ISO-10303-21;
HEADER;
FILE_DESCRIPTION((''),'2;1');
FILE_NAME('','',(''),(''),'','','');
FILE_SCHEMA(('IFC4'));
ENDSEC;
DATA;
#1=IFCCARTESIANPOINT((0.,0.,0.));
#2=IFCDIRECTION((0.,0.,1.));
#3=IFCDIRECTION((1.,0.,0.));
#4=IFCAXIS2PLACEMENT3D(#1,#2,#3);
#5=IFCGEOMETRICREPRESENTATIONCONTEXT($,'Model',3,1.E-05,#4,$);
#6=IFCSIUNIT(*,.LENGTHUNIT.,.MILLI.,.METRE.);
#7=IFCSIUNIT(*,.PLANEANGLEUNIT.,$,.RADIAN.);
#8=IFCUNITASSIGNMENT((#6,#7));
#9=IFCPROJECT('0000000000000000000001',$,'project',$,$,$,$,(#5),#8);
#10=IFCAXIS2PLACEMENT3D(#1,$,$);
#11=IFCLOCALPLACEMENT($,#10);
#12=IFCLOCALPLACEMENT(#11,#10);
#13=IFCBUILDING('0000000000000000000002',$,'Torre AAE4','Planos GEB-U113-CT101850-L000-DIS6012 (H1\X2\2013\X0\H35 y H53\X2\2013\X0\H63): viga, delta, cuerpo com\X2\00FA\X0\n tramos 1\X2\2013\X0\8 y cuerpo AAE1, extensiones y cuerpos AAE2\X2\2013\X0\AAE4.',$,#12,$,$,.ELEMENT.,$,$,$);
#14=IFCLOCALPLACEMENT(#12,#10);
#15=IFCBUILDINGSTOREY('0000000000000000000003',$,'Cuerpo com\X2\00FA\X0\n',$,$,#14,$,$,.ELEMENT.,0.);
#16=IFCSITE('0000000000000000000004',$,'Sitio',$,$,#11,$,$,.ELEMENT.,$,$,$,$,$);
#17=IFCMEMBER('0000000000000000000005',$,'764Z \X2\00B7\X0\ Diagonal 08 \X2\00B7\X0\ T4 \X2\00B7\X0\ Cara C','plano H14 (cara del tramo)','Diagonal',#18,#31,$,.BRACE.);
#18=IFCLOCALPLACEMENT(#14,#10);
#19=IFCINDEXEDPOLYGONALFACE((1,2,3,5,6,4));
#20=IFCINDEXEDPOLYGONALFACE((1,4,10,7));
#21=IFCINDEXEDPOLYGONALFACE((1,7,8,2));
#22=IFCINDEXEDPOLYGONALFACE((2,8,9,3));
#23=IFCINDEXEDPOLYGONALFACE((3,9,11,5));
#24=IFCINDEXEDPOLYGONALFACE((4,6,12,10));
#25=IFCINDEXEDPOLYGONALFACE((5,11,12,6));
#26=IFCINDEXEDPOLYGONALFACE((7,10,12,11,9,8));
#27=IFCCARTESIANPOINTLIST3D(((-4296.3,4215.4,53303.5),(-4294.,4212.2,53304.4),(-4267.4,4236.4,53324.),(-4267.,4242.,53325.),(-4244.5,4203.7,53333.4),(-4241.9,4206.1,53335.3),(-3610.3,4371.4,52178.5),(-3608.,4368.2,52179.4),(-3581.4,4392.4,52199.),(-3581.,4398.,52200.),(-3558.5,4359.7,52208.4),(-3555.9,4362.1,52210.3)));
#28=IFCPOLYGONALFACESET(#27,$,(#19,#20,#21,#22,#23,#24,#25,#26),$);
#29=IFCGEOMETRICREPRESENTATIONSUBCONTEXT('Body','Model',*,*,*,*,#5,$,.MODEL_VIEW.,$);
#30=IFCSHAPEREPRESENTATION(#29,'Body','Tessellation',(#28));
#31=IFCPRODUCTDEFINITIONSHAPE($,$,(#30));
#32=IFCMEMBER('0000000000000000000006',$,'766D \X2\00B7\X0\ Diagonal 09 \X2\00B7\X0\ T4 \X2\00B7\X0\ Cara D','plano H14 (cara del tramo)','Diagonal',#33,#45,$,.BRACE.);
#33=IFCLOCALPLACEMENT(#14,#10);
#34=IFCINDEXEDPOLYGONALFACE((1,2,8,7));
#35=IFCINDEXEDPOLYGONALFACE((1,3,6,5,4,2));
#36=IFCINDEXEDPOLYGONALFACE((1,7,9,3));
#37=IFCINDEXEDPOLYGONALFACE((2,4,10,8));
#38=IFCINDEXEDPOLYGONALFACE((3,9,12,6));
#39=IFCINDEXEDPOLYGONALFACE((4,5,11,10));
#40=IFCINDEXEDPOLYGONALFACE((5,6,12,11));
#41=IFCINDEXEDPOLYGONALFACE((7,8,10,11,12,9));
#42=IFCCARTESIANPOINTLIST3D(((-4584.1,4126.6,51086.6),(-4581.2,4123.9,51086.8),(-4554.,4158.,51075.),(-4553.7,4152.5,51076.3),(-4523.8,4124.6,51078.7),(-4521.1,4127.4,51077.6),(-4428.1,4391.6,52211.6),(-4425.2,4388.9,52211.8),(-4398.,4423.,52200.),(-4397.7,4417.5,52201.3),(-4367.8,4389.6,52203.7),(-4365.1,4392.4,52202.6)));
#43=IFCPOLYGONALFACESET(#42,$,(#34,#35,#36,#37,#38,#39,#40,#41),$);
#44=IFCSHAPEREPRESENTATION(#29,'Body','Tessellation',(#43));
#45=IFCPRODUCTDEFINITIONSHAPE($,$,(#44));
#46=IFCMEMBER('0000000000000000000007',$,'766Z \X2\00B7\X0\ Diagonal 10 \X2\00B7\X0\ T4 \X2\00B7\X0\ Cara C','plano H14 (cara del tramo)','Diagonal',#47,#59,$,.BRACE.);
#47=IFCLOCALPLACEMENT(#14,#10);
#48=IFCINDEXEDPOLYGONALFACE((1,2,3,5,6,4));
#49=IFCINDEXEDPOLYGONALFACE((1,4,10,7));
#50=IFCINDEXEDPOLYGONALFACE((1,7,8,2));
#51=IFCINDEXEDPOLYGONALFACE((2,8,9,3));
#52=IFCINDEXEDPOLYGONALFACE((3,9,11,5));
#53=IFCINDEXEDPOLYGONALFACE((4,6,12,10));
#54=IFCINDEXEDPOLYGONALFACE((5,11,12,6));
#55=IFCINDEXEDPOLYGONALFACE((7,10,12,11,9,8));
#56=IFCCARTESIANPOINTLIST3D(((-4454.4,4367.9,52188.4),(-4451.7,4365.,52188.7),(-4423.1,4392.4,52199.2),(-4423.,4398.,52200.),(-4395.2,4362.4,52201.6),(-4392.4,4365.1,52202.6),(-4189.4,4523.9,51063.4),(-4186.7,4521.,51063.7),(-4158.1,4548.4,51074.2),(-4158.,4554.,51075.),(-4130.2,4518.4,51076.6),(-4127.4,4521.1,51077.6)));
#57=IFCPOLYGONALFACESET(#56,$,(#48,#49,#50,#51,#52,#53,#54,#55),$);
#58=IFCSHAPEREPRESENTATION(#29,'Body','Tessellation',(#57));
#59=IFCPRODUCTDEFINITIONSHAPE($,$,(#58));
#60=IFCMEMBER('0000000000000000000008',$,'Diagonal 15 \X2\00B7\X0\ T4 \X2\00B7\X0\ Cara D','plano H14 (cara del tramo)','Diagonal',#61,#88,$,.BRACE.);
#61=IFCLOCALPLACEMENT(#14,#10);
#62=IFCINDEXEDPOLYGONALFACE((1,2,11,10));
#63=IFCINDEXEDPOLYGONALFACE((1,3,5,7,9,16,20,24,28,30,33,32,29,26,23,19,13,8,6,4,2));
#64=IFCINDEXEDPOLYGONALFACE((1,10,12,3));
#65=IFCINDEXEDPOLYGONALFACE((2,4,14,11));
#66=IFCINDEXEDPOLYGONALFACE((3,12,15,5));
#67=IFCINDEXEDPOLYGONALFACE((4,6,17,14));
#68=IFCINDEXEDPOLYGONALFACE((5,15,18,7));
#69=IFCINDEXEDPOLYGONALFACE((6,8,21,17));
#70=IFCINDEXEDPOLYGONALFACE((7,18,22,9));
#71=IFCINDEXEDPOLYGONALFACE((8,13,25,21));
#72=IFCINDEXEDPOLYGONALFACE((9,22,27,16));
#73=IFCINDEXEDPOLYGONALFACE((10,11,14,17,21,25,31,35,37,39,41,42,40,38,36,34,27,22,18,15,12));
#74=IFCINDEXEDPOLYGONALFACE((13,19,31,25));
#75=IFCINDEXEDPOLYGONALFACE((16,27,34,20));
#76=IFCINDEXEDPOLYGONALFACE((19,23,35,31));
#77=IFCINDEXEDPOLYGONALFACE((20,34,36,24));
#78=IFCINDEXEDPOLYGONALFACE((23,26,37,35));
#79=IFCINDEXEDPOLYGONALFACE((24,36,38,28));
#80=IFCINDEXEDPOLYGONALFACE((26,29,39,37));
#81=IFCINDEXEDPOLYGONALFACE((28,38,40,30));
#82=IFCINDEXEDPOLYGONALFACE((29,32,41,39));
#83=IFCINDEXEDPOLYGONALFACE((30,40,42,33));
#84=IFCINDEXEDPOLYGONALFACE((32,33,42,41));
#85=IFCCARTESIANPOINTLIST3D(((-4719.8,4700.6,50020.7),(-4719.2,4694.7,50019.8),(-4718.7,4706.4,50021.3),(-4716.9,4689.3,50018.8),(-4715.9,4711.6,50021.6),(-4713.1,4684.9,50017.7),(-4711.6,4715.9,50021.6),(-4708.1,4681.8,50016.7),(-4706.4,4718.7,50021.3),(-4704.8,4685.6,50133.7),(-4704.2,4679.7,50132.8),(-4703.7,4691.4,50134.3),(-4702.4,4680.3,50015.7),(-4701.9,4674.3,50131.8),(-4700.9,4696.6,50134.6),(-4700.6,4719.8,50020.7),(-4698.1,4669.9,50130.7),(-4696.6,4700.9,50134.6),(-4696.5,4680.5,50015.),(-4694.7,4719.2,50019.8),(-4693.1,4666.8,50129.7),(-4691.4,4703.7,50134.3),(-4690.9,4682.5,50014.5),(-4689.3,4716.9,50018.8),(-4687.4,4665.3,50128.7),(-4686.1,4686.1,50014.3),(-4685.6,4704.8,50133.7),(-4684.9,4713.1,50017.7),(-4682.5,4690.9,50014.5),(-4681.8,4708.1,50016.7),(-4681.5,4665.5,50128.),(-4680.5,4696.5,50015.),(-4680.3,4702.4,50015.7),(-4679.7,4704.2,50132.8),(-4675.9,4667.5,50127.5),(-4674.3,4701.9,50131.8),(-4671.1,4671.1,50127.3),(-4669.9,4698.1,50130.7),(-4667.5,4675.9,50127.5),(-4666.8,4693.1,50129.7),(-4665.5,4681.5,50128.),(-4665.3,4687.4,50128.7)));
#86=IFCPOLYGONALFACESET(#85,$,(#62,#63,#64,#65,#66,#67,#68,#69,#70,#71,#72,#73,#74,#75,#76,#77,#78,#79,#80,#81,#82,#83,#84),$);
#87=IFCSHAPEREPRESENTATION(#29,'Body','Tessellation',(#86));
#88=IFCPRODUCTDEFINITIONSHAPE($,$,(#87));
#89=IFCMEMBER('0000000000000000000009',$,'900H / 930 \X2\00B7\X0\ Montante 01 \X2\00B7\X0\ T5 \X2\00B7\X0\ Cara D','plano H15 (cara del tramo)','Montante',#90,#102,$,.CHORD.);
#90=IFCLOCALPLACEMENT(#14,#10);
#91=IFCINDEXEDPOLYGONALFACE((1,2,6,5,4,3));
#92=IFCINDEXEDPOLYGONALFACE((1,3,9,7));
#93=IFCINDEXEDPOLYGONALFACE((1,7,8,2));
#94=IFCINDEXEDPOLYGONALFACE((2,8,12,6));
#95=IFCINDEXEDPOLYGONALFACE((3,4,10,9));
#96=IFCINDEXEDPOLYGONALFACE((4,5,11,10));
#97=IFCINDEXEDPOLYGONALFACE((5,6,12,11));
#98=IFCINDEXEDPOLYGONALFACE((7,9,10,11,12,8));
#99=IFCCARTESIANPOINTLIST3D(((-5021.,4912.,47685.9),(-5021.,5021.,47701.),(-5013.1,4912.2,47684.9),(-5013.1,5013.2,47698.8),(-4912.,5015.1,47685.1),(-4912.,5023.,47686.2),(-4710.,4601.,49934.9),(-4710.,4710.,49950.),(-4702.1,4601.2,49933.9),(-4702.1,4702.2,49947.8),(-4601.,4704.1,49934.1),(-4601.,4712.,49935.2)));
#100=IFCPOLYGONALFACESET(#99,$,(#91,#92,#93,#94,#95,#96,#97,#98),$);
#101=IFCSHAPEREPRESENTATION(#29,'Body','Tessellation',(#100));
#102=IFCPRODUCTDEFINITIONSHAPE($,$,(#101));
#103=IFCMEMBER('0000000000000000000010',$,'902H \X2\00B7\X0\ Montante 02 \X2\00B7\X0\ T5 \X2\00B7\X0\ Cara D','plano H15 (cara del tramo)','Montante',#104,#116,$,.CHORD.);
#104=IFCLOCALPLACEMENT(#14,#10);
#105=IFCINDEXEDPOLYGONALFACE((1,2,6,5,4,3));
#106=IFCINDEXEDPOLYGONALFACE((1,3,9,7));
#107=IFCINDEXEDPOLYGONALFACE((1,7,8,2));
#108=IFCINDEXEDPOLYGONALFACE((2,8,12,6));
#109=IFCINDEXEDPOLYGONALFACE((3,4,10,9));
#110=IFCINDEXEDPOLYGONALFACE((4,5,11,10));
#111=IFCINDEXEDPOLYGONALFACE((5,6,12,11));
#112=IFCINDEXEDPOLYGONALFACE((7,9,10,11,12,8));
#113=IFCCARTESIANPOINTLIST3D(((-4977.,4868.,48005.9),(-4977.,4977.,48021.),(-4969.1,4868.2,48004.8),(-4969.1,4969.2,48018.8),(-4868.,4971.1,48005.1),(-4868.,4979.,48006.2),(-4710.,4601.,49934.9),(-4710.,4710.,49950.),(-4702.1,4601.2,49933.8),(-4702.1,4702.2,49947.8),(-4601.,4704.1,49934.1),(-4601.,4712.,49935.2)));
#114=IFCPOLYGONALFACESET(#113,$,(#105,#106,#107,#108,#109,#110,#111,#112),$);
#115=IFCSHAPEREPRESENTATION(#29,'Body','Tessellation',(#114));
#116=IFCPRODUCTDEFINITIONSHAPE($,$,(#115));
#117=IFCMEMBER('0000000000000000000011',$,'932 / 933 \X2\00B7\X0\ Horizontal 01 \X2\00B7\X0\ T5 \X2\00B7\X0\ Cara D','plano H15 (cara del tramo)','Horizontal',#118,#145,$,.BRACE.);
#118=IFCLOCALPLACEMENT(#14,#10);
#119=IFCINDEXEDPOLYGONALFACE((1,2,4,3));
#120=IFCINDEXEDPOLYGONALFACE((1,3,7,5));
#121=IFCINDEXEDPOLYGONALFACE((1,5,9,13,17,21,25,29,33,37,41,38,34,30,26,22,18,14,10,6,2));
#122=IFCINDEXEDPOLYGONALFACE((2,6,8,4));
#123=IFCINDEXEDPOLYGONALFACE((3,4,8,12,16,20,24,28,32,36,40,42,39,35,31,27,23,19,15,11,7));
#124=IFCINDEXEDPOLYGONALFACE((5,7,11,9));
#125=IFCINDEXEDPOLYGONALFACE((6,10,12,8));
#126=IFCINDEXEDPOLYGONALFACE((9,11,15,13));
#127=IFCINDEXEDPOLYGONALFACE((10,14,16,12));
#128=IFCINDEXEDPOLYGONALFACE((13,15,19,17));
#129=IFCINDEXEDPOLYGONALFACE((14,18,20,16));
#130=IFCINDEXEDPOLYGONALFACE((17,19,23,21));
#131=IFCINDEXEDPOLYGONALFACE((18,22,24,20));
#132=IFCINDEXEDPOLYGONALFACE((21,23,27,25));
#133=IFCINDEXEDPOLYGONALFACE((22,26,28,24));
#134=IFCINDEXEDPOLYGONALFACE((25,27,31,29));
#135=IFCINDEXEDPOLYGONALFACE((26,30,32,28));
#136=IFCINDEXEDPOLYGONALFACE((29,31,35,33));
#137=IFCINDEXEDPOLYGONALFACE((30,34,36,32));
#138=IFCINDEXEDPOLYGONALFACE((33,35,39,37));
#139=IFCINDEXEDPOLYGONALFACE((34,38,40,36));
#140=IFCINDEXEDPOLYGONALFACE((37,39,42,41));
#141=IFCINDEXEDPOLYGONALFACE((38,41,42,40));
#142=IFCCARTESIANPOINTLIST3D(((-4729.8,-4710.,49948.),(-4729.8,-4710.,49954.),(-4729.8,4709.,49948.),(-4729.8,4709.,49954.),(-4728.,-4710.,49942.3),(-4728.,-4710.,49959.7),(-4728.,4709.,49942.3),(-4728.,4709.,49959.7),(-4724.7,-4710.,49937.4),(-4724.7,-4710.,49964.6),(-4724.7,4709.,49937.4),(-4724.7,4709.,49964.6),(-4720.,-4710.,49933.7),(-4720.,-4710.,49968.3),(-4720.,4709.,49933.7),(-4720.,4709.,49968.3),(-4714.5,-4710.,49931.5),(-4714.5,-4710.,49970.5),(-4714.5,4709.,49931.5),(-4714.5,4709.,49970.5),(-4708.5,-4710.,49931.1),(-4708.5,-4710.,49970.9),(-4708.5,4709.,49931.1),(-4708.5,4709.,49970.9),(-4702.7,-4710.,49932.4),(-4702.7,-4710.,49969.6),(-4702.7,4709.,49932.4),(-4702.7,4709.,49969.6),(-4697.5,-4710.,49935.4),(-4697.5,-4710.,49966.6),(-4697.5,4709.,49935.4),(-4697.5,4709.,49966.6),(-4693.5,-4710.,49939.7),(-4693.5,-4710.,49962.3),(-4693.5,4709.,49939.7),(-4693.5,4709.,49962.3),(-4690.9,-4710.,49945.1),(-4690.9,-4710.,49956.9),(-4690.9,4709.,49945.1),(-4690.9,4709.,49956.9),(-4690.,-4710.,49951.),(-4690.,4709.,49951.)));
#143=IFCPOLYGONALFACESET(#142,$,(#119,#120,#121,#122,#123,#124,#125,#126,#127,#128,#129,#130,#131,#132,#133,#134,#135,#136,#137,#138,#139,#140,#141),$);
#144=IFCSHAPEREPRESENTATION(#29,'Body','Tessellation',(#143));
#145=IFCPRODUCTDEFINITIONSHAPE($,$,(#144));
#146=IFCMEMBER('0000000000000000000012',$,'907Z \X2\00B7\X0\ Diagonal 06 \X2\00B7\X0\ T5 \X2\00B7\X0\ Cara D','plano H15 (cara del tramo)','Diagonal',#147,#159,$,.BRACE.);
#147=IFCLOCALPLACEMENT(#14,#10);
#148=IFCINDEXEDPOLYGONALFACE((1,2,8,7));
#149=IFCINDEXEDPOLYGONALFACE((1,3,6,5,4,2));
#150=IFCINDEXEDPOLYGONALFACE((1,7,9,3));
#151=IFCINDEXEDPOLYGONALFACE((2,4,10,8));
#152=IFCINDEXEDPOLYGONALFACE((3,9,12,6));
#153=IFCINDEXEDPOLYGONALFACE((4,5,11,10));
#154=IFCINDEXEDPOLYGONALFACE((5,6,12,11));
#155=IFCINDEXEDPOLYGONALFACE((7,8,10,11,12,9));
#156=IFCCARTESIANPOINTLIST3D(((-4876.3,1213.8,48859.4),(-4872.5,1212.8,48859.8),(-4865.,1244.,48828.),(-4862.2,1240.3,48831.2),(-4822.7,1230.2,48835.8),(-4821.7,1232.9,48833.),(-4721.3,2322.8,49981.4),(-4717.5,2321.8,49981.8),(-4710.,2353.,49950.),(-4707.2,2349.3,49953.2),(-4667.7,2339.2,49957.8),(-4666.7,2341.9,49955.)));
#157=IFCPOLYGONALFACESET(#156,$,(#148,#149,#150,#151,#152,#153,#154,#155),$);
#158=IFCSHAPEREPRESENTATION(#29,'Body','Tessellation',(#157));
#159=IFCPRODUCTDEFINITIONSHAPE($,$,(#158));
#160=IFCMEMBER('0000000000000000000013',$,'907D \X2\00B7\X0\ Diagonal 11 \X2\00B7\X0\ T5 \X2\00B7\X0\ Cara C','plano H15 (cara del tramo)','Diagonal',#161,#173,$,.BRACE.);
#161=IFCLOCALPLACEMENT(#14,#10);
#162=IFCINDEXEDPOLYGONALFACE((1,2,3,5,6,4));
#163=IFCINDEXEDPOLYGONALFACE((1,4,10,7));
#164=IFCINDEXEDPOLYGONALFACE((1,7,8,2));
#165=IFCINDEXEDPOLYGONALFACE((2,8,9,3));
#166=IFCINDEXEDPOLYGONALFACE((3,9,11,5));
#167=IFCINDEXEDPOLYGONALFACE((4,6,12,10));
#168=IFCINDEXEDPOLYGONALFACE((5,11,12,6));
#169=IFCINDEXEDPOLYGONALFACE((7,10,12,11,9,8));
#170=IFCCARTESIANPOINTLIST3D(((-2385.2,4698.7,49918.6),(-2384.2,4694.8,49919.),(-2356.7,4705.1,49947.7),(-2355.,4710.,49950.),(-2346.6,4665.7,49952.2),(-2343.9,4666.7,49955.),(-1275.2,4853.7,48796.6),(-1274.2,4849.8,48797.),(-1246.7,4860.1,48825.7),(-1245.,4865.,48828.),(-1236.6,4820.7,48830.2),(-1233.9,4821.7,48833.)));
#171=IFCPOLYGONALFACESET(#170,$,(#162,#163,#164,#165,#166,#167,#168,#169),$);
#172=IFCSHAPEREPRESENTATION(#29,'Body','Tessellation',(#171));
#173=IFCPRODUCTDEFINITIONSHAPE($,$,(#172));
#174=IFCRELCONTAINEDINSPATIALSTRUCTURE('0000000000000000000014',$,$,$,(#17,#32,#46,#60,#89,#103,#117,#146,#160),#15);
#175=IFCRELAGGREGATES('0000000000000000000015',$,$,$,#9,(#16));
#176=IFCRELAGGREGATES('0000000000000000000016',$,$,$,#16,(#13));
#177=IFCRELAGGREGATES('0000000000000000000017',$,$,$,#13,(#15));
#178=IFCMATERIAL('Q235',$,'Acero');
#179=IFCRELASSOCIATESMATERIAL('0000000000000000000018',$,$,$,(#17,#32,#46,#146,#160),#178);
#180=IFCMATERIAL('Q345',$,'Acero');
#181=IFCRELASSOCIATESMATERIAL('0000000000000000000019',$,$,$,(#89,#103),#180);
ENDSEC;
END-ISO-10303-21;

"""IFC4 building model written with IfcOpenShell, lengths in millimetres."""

from ifc_helpers import new_model, si_unit, frame, frame_2d, origin, origin_with_axes, place, context, subcontext, project, spatial, circle, l_section, extrude, material, element, save


model = new_model("IFC4")

# Units and contexts
model_context = context("Model", 3, precision=1e-05, world=origin_with_axes())
body_context = subcontext(model_context, "Body", "Model", "MODEL_VIEW")
ifc_project = project(units=[si_unit("LENGTHUNIT", "METRE", prefix="MILLI"), si_unit("PLANEANGLEUNIT", "RADIAN")], contexts=[model_context])

# Site, building, storey
site_placement = place(None, origin())
site = spatial("IfcSite", under=ifc_project, at=site_placement, Name="Sitio", CompositionType="ELEMENT")
building_placement = place(site_placement, origin())
building = spatial("IfcBuilding", under=site, at=building_placement, Name="Torre AAE4", Description="Planos GEB-U113-CT101850-L000-DIS6012 (H1–H35 y H53–H63): viga, delta, cuerpo común tramos 1–8 y cuerpo AAE1, extensiones y cuerpos AAE2–AAE4.", CompositionType="ELEMENT")
storey_placement = place(building_placement, origin())
storey = spatial("IfcBuildingStorey", under=building, at=storey_placement, Name="Cuerpo común", CompositionType="ELEMENT", Elevation=0.0)

# Members
ifc_material_1 = material(Name="Q235", Category="Acero")
for number, where, z_axis, x_axis, name in (
    (1, (-4267.0, 4242.0, 53325.0), (0.51701, 0.117571, -0.847867), (0.556878, -0.798444, 0.228854), "764Z · Diagonal 08 · T4 · Cara C"),
):
    element("IfcMember", number, at=place(storey_placement, frame(where, z_axis=z_axis, x_axis=x_axis)), inside=storey, material=ifc_material_1, Name=name, Description="plano H14 (cara del tramo)", ObjectType="Diagonal", PredefinedType="BRACE", context=body_context, shape_type="SweptSolid", body=[
        extrude(l_section(Depth=45.0, Width=45.0, Thickness=4.0, at=frame_2d((22.5, 22.5))), None, (0.0, 0.0, 1.0), 1326.9),
    ])
for number, where, z_axis, x_axis, name in (
    (2, (-4398.0, 4423.0, 52200.0), (-0.13376, -0.22722, -0.964614), (0.73137, -0.679455, 0.058633), "766D · Diagonal 09 · T4 · Cara D"),
    (3, (-4423.0, 4398.0, 52200.0), (0.22722, 0.13376, -0.964614), (0.679455, -0.73137, 0.058633), "766Z · Diagonal 10 · T4 · Cara C"),
):
    element("IfcMember", number, at=place(storey_placement, frame(where, z_axis=z_axis, x_axis=x_axis)), inside=storey, material=ifc_material_1, Name=name, Description="plano H14 (cara del tramo)", ObjectType="Diagonal", PredefinedType="BRACE", context=body_context, shape_type="SweptSolid", body=[
        extrude(l_section(Depth=45.0, Width=45.0, Thickness=4.0, at=frame_2d((22.5, 22.5))), None, (0.0, 0.0, 1.0), 1166.3),
    ])
member_1_placement = place(storey_placement, frame((-4685.0, 4685.0, 50131.0), z_axis=(-0.130464, 0.130464, -0.982832), x_axis=(0.694967, -0.694967, -0.184504)))
element("IfcMember", 4, at=member_1_placement, inside=storey, Name="Diagonal 15 · T4 · Cara D", Description="plano H14 (cara del tramo)", ObjectType="Diagonal", PredefinedType="BRACE", context=body_context, shape_type="SweptSolid", body=[
    extrude(circle(Radius=20.0), None, (0.0, 0.0, 1.0), 115.0),
])
ifc_material_2 = material(Name="Q345", Category="Acero")
member_2_placement = place(storey_placement, frame((-4710.0, 4710.0, 49950.0), z_axis=(-0.135713, 0.135713, -0.981409), x_axis=(0.990748, 0.01859, -0.134434)))
element("IfcMember", 5, at=member_2_placement, inside=storey, material=ifc_material_2, Name="900H / 930 · Montante 01 · T5 · Cara D", Description="plano H15 (cara del tramo)", ObjectType="Montante", PredefinedType="CHORD", context=body_context, shape_type="SweptSolid", body=[
    extrude(l_section(Depth=110.0, Width=110.0, Thickness=8.0, at=frame_2d((55.0, 55.0))), None, (0.0, 0.0, 1.0), 2291.6),
])
member_3_placement = place(storey_placement, frame((-4710.0, 4710.0, 49950.0), z_axis=(-0.135836, 0.135836, -0.981375), x_axis=(0.990731, 0.018624, -0.134553)))
element("IfcMember", 6, at=member_3_placement, inside=storey, material=ifc_material_2, Name="902H · Montante 02 · T5 · Cara D", Description="plano H15 (cara del tramo)", ObjectType="Montante", PredefinedType="CHORD", context=body_context, shape_type="SweptSolid", body=[
    extrude(l_section(Depth=110.0, Width=110.0, Thickness=8.0, at=frame_2d((55.0, 55.0))), None, (0.0, 0.0, 1.0), 1965.6),
])
member_4_placement = place(storey_placement, frame((-4710.0, 4709.0, 49951.0), z_axis=(0.0, -1.0, 0.0), x_axis=(1.0, 0.0, 0.0)))
element("IfcMember", 7, at=member_4_placement, inside=storey, Name="932 / 933 · Horizontal 01 · T5 · Cara D", Description="plano H15 (cara del tramo)", ObjectType="Horizontal", PredefinedType="BRACE", context=body_context, shape_type="SweptSolid", body=[
    extrude(circle(Radius=20.0), None, (0.0, 0.0, 1.0), 9419.0),
])
member_5_placement = place(storey_placement, frame((-4710.0, 2353.0, 49950.0), z_axis=(-0.097781, -0.699606, -0.707807), x_axis=(0.962791, -0.246544, 0.110682)))
element("IfcMember", 8, at=member_5_placement, inside=storey, material=ifc_material_1, Name="907Z · Diagonal 06 · T5 · Cara D", Description="plano H15 (cara del tramo)", ObjectType="Diagonal", PredefinedType="BRACE", context=body_context, shape_type="SweptSolid", body=[
    extrude(l_section(Depth=45.0, Width=45.0, Thickness=4.0, at=frame_2d((22.5, 22.5))), None, (0.0, 0.0, 1.0), 1585.2),
])
member_6_placement = place(storey_placement, frame((-2355.0, 4710.0, 49950.0), z_axis=(0.699928, 0.097738, -0.707495), x_axis=(0.246524, -0.962772, 0.110884)))
element("IfcMember", 9, at=member_6_placement, inside=storey, material=ifc_material_1, Name="907D · Diagonal 11 · T5 · Cara C", Description="plano H15 (cara del tramo)", ObjectType="Diagonal", PredefinedType="BRACE", context=body_context, shape_type="SweptSolid", body=[
    extrude(l_section(Depth=45.0, Width=45.0, Thickness=4.0, at=frame_2d((22.5, 22.5))), None, (0.0, 0.0, 1.0), 1585.9),
])

save(model, "model.ifc")
